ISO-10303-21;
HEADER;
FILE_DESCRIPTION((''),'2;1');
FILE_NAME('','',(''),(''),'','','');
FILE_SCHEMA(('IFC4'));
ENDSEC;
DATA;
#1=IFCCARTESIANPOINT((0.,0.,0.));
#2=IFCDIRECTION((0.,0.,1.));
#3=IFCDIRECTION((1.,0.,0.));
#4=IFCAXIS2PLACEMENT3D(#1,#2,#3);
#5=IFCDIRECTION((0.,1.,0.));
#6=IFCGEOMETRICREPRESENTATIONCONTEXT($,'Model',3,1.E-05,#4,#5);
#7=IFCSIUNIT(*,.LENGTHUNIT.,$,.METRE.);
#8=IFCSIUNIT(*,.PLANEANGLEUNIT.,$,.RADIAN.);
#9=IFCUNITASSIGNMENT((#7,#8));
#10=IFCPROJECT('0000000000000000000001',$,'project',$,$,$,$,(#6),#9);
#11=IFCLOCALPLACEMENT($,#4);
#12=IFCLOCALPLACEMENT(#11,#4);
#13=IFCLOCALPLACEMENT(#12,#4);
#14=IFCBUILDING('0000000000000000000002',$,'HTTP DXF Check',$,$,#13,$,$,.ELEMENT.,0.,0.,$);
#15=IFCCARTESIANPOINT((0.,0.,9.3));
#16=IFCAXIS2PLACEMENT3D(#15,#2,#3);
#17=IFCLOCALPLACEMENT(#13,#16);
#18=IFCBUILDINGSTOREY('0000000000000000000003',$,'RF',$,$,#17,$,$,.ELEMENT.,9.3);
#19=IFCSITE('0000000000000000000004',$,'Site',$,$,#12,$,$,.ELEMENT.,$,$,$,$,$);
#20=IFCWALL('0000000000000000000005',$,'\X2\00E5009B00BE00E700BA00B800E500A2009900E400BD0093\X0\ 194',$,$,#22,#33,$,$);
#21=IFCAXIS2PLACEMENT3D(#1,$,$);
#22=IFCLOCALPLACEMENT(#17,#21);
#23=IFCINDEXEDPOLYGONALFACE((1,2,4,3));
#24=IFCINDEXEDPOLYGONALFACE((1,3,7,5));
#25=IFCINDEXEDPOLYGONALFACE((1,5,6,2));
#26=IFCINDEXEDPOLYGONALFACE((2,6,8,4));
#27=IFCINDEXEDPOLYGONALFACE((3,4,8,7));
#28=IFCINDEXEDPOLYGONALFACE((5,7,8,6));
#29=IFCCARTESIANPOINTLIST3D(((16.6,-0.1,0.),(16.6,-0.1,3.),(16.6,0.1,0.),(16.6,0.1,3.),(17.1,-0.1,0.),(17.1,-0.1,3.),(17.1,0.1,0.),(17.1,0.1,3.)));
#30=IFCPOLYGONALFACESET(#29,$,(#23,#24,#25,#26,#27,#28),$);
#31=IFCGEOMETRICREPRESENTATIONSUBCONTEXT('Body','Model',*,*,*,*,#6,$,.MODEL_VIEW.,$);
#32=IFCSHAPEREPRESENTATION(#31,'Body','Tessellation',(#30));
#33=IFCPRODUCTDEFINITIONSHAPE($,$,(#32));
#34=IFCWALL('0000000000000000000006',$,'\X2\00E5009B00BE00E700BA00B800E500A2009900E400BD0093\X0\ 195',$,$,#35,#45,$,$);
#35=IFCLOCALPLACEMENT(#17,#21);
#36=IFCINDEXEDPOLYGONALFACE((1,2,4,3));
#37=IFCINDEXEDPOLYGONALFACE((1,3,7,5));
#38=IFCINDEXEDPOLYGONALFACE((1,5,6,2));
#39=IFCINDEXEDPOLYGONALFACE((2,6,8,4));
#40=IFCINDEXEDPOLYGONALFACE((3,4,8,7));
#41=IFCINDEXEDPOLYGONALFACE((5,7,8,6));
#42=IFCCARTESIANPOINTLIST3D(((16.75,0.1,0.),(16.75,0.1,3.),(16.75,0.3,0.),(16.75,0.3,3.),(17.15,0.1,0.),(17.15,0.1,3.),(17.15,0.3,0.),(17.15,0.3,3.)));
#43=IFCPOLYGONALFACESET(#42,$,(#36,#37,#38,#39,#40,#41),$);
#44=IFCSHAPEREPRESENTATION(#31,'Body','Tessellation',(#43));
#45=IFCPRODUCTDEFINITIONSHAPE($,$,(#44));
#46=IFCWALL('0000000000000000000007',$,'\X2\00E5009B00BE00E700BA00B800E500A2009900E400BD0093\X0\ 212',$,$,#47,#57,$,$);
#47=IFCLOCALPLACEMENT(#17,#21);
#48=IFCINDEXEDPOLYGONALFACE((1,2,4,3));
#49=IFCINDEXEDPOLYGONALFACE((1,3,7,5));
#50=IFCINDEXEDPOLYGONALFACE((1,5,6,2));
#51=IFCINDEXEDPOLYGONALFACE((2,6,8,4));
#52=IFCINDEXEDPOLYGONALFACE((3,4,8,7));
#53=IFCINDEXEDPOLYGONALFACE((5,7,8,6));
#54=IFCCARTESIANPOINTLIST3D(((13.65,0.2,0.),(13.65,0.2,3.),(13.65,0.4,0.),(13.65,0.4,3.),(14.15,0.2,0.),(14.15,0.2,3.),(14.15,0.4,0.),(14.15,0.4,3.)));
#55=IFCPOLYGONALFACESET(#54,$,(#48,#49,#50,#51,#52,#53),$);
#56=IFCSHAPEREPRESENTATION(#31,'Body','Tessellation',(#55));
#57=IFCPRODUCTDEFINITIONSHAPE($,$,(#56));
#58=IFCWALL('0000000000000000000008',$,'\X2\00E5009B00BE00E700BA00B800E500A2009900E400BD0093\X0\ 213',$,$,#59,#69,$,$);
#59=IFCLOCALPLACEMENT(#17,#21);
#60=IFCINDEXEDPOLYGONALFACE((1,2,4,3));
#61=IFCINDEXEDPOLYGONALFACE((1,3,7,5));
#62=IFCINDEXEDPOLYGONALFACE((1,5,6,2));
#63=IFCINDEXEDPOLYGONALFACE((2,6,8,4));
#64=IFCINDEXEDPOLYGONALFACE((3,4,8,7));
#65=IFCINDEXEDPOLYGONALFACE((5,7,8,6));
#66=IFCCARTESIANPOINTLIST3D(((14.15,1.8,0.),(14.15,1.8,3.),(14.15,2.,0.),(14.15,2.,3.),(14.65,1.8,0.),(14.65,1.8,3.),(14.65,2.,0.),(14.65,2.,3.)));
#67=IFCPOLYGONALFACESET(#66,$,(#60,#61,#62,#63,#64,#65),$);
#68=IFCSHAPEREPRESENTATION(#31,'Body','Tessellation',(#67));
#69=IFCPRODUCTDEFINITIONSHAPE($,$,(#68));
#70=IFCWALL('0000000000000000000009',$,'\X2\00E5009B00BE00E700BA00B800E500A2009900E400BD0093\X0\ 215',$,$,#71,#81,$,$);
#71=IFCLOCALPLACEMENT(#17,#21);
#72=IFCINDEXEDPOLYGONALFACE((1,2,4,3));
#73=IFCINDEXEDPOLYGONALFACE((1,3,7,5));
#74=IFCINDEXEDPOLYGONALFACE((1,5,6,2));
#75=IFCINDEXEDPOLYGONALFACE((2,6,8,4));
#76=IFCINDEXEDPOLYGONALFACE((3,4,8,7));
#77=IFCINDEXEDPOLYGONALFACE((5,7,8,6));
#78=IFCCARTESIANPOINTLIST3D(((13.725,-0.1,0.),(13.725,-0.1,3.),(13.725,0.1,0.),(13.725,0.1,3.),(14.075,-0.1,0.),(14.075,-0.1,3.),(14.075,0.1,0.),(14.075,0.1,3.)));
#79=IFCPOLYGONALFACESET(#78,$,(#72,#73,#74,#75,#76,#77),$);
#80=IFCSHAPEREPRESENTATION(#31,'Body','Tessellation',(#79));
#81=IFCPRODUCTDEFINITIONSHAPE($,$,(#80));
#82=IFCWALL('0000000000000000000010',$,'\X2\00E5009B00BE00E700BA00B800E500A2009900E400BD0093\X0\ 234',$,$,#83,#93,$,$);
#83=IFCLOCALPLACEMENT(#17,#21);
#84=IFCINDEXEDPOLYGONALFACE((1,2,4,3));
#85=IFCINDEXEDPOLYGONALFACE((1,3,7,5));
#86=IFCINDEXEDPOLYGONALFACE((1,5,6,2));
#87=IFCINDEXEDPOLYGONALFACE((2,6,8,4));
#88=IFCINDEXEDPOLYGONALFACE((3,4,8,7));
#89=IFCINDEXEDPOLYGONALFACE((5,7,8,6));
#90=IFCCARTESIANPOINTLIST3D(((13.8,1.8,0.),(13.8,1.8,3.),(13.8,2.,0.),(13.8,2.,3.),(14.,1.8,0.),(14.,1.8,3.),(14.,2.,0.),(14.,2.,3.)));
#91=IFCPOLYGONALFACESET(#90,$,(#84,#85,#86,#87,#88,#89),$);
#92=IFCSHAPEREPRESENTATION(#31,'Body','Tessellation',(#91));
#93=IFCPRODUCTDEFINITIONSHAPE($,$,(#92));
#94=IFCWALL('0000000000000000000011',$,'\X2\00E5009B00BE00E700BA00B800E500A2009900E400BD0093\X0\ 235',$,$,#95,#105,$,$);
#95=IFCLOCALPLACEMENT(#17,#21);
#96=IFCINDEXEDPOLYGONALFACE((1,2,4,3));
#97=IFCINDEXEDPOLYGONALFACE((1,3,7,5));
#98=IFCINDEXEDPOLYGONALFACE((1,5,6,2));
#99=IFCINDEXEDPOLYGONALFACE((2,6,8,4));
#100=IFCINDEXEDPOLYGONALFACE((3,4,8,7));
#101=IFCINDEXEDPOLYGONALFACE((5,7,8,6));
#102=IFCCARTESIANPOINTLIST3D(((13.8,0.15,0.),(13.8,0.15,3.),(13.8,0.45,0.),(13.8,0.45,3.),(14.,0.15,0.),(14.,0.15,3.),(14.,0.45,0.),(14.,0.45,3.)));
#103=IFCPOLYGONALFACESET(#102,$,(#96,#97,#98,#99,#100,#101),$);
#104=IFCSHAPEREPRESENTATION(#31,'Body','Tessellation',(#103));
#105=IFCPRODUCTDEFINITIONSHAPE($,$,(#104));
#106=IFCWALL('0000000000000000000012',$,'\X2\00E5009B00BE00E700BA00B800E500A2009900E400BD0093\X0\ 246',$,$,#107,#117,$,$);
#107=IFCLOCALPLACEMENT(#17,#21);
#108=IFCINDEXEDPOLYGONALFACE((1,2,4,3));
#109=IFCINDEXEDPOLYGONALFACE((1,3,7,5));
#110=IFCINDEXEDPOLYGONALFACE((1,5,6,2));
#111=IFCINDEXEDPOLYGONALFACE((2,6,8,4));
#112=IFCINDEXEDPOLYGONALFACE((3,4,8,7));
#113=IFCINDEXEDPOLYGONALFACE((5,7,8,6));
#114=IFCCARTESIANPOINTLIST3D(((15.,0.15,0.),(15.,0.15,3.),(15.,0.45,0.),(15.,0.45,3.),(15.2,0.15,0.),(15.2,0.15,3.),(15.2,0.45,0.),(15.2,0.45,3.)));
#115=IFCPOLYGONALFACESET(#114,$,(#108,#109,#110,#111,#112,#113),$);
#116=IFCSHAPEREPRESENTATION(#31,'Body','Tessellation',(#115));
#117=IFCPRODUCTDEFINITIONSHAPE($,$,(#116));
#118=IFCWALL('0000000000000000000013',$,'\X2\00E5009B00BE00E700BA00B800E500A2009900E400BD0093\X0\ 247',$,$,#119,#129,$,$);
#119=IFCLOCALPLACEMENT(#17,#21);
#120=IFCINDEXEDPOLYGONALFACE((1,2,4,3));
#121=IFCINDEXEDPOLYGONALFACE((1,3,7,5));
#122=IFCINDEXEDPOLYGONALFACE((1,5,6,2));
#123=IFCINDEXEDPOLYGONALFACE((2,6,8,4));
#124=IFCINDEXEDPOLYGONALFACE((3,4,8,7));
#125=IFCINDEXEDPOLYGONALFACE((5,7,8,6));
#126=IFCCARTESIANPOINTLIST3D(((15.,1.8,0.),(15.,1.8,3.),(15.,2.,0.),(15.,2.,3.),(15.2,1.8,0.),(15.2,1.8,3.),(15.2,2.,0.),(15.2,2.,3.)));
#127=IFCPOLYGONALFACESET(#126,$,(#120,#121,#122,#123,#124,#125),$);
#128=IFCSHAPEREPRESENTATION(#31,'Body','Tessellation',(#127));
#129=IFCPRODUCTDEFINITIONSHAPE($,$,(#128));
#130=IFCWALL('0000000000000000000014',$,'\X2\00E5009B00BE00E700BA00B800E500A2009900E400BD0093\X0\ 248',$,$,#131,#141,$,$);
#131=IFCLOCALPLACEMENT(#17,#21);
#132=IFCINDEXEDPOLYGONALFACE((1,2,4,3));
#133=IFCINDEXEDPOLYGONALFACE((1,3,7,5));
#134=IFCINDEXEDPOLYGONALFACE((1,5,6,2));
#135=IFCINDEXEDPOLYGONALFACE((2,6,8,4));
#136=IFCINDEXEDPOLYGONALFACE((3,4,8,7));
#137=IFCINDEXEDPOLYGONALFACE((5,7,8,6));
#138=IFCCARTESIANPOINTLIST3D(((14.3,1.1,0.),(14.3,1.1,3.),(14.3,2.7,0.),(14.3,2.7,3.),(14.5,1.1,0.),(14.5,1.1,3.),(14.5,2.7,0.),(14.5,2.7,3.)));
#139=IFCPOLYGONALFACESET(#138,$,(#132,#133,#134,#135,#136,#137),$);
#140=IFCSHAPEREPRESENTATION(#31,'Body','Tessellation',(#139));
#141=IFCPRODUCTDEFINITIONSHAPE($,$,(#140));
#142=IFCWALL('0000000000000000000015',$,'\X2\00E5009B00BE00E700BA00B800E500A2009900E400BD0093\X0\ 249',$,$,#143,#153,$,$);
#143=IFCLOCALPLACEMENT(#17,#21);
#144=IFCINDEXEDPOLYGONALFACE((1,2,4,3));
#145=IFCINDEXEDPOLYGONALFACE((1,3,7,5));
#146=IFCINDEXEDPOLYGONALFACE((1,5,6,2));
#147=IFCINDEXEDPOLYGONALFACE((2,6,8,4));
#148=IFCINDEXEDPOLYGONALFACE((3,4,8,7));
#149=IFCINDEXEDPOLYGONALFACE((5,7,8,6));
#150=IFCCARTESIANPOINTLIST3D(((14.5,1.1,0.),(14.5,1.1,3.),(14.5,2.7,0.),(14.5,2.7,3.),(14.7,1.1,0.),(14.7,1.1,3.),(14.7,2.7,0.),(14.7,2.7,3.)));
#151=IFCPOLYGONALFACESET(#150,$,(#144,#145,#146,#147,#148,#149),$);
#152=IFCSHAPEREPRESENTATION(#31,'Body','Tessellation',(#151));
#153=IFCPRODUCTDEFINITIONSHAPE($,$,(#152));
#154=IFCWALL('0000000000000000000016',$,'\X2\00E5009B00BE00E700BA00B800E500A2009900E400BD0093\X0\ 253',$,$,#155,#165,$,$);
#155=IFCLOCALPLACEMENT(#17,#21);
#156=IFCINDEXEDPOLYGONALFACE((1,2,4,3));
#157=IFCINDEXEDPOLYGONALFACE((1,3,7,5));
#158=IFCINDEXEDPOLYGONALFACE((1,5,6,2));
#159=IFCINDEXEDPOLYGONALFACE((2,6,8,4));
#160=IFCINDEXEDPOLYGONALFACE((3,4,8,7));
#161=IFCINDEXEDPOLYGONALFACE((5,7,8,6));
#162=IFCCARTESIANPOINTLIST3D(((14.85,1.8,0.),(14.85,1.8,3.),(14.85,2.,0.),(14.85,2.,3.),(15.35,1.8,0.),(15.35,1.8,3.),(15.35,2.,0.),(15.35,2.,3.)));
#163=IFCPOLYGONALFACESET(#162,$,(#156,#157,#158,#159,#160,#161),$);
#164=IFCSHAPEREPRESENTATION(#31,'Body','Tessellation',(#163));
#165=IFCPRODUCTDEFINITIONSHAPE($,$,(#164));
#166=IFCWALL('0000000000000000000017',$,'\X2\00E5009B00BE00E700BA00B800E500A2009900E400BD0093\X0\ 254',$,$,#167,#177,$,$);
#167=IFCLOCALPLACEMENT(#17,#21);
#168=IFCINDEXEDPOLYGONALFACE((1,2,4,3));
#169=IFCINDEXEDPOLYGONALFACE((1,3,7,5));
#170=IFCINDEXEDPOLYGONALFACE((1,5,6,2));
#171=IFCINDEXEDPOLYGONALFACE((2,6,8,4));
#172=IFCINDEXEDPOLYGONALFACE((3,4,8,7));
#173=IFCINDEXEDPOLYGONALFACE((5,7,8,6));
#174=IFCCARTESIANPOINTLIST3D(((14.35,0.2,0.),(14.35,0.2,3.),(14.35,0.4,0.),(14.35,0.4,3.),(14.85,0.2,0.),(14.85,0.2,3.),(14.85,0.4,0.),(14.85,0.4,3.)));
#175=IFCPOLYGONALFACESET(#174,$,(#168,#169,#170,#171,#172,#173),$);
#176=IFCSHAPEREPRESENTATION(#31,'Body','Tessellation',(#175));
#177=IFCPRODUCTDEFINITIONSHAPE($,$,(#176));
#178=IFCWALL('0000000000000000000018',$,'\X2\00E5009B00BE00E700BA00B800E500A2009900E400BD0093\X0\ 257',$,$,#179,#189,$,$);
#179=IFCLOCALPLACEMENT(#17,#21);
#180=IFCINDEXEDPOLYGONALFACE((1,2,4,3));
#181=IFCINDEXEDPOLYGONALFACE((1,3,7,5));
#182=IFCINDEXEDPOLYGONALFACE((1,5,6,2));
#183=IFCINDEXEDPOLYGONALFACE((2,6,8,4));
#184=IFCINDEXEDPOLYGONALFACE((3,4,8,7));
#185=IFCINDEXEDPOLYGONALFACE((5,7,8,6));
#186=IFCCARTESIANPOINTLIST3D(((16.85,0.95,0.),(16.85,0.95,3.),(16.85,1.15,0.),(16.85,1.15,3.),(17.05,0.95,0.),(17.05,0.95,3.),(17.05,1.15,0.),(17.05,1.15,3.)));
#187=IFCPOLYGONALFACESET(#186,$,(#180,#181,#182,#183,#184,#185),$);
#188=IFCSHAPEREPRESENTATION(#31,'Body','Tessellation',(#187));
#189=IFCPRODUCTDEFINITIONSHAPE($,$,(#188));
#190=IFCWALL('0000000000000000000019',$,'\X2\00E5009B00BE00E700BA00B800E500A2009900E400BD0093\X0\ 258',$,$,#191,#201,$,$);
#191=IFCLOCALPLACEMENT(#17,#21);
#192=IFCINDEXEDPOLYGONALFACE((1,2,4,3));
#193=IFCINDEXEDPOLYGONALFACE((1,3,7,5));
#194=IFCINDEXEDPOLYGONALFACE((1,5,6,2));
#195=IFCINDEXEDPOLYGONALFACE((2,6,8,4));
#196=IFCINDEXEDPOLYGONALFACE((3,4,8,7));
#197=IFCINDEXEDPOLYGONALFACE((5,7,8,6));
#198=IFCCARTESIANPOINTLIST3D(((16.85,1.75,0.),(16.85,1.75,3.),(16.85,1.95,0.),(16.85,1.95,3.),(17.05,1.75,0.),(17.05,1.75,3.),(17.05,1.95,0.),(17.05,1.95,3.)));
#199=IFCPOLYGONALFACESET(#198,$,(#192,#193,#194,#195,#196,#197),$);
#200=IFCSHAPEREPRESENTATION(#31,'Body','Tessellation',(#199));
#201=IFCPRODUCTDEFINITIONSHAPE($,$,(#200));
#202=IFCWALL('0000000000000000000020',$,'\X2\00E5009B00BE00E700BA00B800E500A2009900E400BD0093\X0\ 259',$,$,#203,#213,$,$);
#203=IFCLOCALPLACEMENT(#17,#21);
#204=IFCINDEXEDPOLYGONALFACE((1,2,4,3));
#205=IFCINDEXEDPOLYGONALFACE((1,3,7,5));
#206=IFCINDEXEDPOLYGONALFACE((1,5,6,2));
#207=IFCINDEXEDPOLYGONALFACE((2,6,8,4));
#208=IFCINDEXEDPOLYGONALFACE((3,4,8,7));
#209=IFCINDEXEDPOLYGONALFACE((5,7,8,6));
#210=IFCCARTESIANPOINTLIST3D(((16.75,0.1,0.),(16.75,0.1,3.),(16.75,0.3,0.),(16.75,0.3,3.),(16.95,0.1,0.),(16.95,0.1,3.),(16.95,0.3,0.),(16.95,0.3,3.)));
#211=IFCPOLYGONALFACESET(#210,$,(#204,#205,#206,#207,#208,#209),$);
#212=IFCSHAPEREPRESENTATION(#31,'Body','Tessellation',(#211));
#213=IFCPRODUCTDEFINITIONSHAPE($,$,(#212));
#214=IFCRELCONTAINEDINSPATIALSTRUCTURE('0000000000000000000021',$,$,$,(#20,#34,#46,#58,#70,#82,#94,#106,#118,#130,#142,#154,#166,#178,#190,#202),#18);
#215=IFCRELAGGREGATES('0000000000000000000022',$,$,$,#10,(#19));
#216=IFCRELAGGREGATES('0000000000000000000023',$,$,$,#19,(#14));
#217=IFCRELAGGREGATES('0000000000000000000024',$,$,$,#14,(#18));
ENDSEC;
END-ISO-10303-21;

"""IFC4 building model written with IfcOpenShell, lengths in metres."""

from ifc_helpers import new_model, si_unit, direction, frame, frame_2d, origin_with_axes, place, context, subcontext, project, spatial, rectangle, extrude, element, save


model = new_model("IFC4")

# Units and contexts
model_context = context("Model", 3, precision=1e-05, world=origin_with_axes(), true_north=direction((0.0, 1.0, 0.0)))
body_context = subcontext(model_context, "Body", "Model", "MODEL_VIEW")
ifc_project = project(units=[si_unit("LENGTHUNIT", "METRE"), si_unit("PLANEANGLEUNIT", "RADIAN")], contexts=[model_context])

# Site, building, storey
placement = place(None, origin_with_axes())
site_placement = place(placement, origin_with_axes())
site = spatial("IfcSite", under=ifc_project, at=site_placement, Name="Site", CompositionType="ELEMENT")
building_placement = place(site_placement, origin_with_axes())
building = spatial("IfcBuilding", under=site, at=building_placement, Name="HTTP DXF Check", CompositionType="ELEMENT", ElevationOfRefHeight=0.0, ElevationOfTerrain=0.0)
storey_placement = place(building_placement, frame((0.0, 0.0, 9.3), z_axis=(0.0, 0.0, 1.0), x_axis=(1.0, 0.0, 0.0)))
storey = spatial("IfcBuildingStorey", under=building, at=storey_placement, Name="RF", CompositionType="ELEMENT", Elevation=9.3)

# Walls
wall_1_placement = place(storey_placement, frame((16.85, 0.0, 0.0), z_axis=(0.0, 0.0, 1.0), x_axis=(1.0, 0.0, 0.0)))
element("IfcWall", 1, at=wall_1_placement, inside=storey, Name="å\u009b¾çº¸å¢\u0099ä½\u0093 194", context=body_context, shape_type="SweptSolid", body=[
    extrude(rectangle(XDim=0.5, YDim=0.2, at=frame_2d((0.0, 0.0), x_axis=(1.0, 0.0, 0.0))), frame((0.0, 0.0, 0.0), z_axis=(0.0, 0.0, 1.0)), (0.0, 0.0, 1.0), 3.0),
])
wall_2_placement = place(storey_placement, frame((16.95, 0.2, 0.0), z_axis=(0.0, 0.0, 1.0), x_axis=(1.0, 0.0, 0.0)))
element("IfcWall", 2, at=wall_2_placement, inside=storey, Name="å\u009b¾çº¸å¢\u0099ä½\u0093 195", context=body_context, shape_type="SweptSolid", body=[
    extrude(rectangle(XDim=0.4, YDim=0.2, at=frame_2d((0.0, 0.0), x_axis=(1.0, 0.0, 0.0))), frame((0.0, 0.0, 0.0), z_axis=(0.0, 0.0, 1.0)), (0.0, 0.0, 1.0), 3.0),
])
for number, where, z_axis, x_axis, name in (
    (3, (13.9, 0.3, 0.0), (0.0, 0.0, 1.0), (1.0, 0.0, 0.0), "å\u009b¾çº¸å¢\u0099ä½\u0093 212"),
    (4, (14.4, 1.9, 0.0), (0.0, 0.0, 1.0), (-1.0, 0.0, 0.0), "å\u009b¾çº¸å¢\u0099ä½\u0093 213"),
):
    element("IfcWall", number, at=place(storey_placement, frame(where, z_axis=z_axis, x_axis=x_axis)), inside=storey, Name=name, context=body_context, shape_type="SweptSolid", body=[
        extrude(rectangle(XDim=0.5, YDim=0.2, at=frame_2d((0.0, 0.0), x_axis=(1.0, 0.0, 0.0))), frame((0.0, 0.0, 0.0), z_axis=(0.0, 0.0, 1.0)), (0.0, 0.0, 1.0), 3.0),
    ])
wall_3_placement = place(storey_placement, frame((13.9, 0.0, 0.0), z_axis=(0.0, 0.0, 1.0), x_axis=(1.0, 0.0, 0.0)))
element("IfcWall", 5, at=wall_3_placement, inside=storey, Name="å\u009b¾çº¸å¢\u0099ä½\u0093 215", context=body_context, shape_type="SweptSolid", body=[
    extrude(rectangle(XDim=0.35, YDim=0.2, at=frame_2d((0.0, 0.0), x_axis=(1.0, 0.0, 0.0))), frame((0.0, 0.0, 0.0), z_axis=(0.0, 0.0, 1.0)), (0.0, 0.0, 1.0), 3.0),
])
wall_4_placement = place(storey_placement, frame((13.9, 1.9, 0.0), z_axis=(0.0, 0.0, 1.0), x_axis=(0.0, 1.0, 0.0)))
element("IfcWall", 6, at=wall_4_placement, inside=storey, Name="å\u009b¾çº¸å¢\u0099ä½\u0093 234", context=body_context, shape_type="SweptSolid", body=[
    extrude(rectangle(XDim=0.2, YDim=0.2, at=frame_2d((0.0, 0.0), x_axis=(1.0, 0.0, 0.0))), frame((0.0, 0.0, 0.0), z_axis=(0.0, 0.0, 1.0)), (0.0, 0.0, 1.0), 3.0),
])
for number, where, z_axis, x_axis, name in (
    (7, (13.9, 0.3, 0.0), (0.0, 0.0, 1.0), (0.0, -1.0, 0.0), "å\u009b¾çº¸å¢\u0099ä½\u0093 235"),
    (8, (15.1, 0.3, 0.0), (0.0, 0.0, 1.0), (0.0, -1.0, 0.0), "å\u009b¾çº¸å¢\u0099ä½\u0093 246"),
):
    element("IfcWall", number, at=place(storey_placement, frame(where, z_axis=z_axis, x_axis=x_axis)), inside=storey, Name=name, context=body_context, shape_type="SweptSolid", body=[
        extrude(rectangle(XDim=0.3, YDim=0.2, at=frame_2d((0.0, 0.0), x_axis=(1.0, 0.0, 0.0))), frame((0.0, 0.0, 0.0), z_axis=(0.0, 0.0, 1.0)), (0.0, 0.0, 1.0), 3.0),
    ])
wall_5_placement = place(storey_placement, frame((15.1, 1.9, 0.0), z_axis=(0.0, 0.0, 1.0), x_axis=(0.0, 1.0, 0.0)))
element("IfcWall", 9, at=wall_5_placement, inside=storey, Name="å\u009b¾çº¸å¢\u0099ä½\u0093 247", context=body_context, shape_type="SweptSolid", body=[
    extrude(rectangle(XDim=0.2, YDim=0.2, at=frame_2d((0.0, 0.0), x_axis=(1.0, 0.0, 0.0))), frame((0.0, 0.0, 0.0), z_axis=(0.0, 0.0, 1.0)), (0.0, 0.0, 1.0), 3.0),
])
for number, where, z_axis, x_axis, name in (
    (10, (14.4, 1.9, 0.0), (0.0, 0.0, 1.0), (0.0, -1.0, 0.0), "å\u009b¾çº¸å¢\u0099ä½\u0093 248"),
    (11, (14.6, 1.9, 0.0), (0.0, 0.0, 1.0), (0.0, -1.0, 0.0), "å\u009b¾çº¸å¢\u0099ä½\u0093 249"),
):
    element("IfcWall", number, at=place(storey_placement, frame(where, z_axis=z_axis, x_axis=x_axis)), inside=storey, Name=name, context=body_context, shape_type="SweptSolid", body=[
        extrude(rectangle(XDim=1.6, YDim=0.2, at=frame_2d((0.0, 0.0), x_axis=(1.0, 0.0, 0.0))), frame((0.0, 0.0, 0.0), z_axis=(0.0, 0.0, 1.0)), (0.0, 0.0, 1.0), 3.0),
    ])
for number, where, z_axis, x_axis, name in (
    (12, (15.1, 1.9, 0.0), (0.0, 0.0, 1.0), (-1.0, 0.0, 0.0), "å\u009b¾çº¸å¢\u0099ä½\u0093 253"),
    (13, (14.6, 0.3, 0.0), (0.0, 0.0, 1.0), (1.0, 0.0, 0.0), "å\u009b¾çº¸å¢\u0099ä½\u0093 254"),
):
    element("IfcWall", number, at=place(storey_placement, frame(where, z_axis=z_axis, x_axis=x_axis)), inside=storey, Name=name, context=body_context, shape_type="SweptSolid", body=[
        extrude(rectangle(XDim=0.5, YDim=0.2, at=frame_2d((0.0, 0.0), x_axis=(1.0, 0.0, 0.0))), frame((0.0, 0.0, 0.0), z_axis=(0.0, 0.0, 1.0)), (0.0, 0.0, 1.0), 3.0),
    ])
for number, where, z_axis, x_axis, name in (
    (14, (16.95, 1.05, 0.0), (0.0, 0.0, 1.0), (-1.0, 0.0, 0.0), "å\u009b¾çº¸å¢\u0099ä½\u0093 257"),
    (15, (16.95, 1.85, 0.0), (0.0, 0.0, 1.0), (-1.0, 0.0, 0.0), "å\u009b¾çº¸å¢\u0099ä½\u0093 258"),
    (16, (16.85, 0.2, 0.0), (0.0, 0.0, 1.0), (0.0, -1.0, 0.0), "å\u009b¾çº¸å¢\u0099ä½\u0093 259"),
):
    element("IfcWall", number, at=place(storey_placement, frame(where, z_axis=z_axis, x_axis=x_axis)), inside=storey, Name=name, context=body_context, shape_type="SweptSolid", body=[
        extrude(rectangle(XDim=0.2, YDim=0.2, at=frame_2d((0.0, 0.0), x_axis=(1.0, 0.0, 0.0))), frame((0.0, 0.0, 0.0), z_axis=(0.0, 0.0, 1.0)), (0.0, 0.0, 1.0), 3.0),
    ])

save(model, "model.ifc")
